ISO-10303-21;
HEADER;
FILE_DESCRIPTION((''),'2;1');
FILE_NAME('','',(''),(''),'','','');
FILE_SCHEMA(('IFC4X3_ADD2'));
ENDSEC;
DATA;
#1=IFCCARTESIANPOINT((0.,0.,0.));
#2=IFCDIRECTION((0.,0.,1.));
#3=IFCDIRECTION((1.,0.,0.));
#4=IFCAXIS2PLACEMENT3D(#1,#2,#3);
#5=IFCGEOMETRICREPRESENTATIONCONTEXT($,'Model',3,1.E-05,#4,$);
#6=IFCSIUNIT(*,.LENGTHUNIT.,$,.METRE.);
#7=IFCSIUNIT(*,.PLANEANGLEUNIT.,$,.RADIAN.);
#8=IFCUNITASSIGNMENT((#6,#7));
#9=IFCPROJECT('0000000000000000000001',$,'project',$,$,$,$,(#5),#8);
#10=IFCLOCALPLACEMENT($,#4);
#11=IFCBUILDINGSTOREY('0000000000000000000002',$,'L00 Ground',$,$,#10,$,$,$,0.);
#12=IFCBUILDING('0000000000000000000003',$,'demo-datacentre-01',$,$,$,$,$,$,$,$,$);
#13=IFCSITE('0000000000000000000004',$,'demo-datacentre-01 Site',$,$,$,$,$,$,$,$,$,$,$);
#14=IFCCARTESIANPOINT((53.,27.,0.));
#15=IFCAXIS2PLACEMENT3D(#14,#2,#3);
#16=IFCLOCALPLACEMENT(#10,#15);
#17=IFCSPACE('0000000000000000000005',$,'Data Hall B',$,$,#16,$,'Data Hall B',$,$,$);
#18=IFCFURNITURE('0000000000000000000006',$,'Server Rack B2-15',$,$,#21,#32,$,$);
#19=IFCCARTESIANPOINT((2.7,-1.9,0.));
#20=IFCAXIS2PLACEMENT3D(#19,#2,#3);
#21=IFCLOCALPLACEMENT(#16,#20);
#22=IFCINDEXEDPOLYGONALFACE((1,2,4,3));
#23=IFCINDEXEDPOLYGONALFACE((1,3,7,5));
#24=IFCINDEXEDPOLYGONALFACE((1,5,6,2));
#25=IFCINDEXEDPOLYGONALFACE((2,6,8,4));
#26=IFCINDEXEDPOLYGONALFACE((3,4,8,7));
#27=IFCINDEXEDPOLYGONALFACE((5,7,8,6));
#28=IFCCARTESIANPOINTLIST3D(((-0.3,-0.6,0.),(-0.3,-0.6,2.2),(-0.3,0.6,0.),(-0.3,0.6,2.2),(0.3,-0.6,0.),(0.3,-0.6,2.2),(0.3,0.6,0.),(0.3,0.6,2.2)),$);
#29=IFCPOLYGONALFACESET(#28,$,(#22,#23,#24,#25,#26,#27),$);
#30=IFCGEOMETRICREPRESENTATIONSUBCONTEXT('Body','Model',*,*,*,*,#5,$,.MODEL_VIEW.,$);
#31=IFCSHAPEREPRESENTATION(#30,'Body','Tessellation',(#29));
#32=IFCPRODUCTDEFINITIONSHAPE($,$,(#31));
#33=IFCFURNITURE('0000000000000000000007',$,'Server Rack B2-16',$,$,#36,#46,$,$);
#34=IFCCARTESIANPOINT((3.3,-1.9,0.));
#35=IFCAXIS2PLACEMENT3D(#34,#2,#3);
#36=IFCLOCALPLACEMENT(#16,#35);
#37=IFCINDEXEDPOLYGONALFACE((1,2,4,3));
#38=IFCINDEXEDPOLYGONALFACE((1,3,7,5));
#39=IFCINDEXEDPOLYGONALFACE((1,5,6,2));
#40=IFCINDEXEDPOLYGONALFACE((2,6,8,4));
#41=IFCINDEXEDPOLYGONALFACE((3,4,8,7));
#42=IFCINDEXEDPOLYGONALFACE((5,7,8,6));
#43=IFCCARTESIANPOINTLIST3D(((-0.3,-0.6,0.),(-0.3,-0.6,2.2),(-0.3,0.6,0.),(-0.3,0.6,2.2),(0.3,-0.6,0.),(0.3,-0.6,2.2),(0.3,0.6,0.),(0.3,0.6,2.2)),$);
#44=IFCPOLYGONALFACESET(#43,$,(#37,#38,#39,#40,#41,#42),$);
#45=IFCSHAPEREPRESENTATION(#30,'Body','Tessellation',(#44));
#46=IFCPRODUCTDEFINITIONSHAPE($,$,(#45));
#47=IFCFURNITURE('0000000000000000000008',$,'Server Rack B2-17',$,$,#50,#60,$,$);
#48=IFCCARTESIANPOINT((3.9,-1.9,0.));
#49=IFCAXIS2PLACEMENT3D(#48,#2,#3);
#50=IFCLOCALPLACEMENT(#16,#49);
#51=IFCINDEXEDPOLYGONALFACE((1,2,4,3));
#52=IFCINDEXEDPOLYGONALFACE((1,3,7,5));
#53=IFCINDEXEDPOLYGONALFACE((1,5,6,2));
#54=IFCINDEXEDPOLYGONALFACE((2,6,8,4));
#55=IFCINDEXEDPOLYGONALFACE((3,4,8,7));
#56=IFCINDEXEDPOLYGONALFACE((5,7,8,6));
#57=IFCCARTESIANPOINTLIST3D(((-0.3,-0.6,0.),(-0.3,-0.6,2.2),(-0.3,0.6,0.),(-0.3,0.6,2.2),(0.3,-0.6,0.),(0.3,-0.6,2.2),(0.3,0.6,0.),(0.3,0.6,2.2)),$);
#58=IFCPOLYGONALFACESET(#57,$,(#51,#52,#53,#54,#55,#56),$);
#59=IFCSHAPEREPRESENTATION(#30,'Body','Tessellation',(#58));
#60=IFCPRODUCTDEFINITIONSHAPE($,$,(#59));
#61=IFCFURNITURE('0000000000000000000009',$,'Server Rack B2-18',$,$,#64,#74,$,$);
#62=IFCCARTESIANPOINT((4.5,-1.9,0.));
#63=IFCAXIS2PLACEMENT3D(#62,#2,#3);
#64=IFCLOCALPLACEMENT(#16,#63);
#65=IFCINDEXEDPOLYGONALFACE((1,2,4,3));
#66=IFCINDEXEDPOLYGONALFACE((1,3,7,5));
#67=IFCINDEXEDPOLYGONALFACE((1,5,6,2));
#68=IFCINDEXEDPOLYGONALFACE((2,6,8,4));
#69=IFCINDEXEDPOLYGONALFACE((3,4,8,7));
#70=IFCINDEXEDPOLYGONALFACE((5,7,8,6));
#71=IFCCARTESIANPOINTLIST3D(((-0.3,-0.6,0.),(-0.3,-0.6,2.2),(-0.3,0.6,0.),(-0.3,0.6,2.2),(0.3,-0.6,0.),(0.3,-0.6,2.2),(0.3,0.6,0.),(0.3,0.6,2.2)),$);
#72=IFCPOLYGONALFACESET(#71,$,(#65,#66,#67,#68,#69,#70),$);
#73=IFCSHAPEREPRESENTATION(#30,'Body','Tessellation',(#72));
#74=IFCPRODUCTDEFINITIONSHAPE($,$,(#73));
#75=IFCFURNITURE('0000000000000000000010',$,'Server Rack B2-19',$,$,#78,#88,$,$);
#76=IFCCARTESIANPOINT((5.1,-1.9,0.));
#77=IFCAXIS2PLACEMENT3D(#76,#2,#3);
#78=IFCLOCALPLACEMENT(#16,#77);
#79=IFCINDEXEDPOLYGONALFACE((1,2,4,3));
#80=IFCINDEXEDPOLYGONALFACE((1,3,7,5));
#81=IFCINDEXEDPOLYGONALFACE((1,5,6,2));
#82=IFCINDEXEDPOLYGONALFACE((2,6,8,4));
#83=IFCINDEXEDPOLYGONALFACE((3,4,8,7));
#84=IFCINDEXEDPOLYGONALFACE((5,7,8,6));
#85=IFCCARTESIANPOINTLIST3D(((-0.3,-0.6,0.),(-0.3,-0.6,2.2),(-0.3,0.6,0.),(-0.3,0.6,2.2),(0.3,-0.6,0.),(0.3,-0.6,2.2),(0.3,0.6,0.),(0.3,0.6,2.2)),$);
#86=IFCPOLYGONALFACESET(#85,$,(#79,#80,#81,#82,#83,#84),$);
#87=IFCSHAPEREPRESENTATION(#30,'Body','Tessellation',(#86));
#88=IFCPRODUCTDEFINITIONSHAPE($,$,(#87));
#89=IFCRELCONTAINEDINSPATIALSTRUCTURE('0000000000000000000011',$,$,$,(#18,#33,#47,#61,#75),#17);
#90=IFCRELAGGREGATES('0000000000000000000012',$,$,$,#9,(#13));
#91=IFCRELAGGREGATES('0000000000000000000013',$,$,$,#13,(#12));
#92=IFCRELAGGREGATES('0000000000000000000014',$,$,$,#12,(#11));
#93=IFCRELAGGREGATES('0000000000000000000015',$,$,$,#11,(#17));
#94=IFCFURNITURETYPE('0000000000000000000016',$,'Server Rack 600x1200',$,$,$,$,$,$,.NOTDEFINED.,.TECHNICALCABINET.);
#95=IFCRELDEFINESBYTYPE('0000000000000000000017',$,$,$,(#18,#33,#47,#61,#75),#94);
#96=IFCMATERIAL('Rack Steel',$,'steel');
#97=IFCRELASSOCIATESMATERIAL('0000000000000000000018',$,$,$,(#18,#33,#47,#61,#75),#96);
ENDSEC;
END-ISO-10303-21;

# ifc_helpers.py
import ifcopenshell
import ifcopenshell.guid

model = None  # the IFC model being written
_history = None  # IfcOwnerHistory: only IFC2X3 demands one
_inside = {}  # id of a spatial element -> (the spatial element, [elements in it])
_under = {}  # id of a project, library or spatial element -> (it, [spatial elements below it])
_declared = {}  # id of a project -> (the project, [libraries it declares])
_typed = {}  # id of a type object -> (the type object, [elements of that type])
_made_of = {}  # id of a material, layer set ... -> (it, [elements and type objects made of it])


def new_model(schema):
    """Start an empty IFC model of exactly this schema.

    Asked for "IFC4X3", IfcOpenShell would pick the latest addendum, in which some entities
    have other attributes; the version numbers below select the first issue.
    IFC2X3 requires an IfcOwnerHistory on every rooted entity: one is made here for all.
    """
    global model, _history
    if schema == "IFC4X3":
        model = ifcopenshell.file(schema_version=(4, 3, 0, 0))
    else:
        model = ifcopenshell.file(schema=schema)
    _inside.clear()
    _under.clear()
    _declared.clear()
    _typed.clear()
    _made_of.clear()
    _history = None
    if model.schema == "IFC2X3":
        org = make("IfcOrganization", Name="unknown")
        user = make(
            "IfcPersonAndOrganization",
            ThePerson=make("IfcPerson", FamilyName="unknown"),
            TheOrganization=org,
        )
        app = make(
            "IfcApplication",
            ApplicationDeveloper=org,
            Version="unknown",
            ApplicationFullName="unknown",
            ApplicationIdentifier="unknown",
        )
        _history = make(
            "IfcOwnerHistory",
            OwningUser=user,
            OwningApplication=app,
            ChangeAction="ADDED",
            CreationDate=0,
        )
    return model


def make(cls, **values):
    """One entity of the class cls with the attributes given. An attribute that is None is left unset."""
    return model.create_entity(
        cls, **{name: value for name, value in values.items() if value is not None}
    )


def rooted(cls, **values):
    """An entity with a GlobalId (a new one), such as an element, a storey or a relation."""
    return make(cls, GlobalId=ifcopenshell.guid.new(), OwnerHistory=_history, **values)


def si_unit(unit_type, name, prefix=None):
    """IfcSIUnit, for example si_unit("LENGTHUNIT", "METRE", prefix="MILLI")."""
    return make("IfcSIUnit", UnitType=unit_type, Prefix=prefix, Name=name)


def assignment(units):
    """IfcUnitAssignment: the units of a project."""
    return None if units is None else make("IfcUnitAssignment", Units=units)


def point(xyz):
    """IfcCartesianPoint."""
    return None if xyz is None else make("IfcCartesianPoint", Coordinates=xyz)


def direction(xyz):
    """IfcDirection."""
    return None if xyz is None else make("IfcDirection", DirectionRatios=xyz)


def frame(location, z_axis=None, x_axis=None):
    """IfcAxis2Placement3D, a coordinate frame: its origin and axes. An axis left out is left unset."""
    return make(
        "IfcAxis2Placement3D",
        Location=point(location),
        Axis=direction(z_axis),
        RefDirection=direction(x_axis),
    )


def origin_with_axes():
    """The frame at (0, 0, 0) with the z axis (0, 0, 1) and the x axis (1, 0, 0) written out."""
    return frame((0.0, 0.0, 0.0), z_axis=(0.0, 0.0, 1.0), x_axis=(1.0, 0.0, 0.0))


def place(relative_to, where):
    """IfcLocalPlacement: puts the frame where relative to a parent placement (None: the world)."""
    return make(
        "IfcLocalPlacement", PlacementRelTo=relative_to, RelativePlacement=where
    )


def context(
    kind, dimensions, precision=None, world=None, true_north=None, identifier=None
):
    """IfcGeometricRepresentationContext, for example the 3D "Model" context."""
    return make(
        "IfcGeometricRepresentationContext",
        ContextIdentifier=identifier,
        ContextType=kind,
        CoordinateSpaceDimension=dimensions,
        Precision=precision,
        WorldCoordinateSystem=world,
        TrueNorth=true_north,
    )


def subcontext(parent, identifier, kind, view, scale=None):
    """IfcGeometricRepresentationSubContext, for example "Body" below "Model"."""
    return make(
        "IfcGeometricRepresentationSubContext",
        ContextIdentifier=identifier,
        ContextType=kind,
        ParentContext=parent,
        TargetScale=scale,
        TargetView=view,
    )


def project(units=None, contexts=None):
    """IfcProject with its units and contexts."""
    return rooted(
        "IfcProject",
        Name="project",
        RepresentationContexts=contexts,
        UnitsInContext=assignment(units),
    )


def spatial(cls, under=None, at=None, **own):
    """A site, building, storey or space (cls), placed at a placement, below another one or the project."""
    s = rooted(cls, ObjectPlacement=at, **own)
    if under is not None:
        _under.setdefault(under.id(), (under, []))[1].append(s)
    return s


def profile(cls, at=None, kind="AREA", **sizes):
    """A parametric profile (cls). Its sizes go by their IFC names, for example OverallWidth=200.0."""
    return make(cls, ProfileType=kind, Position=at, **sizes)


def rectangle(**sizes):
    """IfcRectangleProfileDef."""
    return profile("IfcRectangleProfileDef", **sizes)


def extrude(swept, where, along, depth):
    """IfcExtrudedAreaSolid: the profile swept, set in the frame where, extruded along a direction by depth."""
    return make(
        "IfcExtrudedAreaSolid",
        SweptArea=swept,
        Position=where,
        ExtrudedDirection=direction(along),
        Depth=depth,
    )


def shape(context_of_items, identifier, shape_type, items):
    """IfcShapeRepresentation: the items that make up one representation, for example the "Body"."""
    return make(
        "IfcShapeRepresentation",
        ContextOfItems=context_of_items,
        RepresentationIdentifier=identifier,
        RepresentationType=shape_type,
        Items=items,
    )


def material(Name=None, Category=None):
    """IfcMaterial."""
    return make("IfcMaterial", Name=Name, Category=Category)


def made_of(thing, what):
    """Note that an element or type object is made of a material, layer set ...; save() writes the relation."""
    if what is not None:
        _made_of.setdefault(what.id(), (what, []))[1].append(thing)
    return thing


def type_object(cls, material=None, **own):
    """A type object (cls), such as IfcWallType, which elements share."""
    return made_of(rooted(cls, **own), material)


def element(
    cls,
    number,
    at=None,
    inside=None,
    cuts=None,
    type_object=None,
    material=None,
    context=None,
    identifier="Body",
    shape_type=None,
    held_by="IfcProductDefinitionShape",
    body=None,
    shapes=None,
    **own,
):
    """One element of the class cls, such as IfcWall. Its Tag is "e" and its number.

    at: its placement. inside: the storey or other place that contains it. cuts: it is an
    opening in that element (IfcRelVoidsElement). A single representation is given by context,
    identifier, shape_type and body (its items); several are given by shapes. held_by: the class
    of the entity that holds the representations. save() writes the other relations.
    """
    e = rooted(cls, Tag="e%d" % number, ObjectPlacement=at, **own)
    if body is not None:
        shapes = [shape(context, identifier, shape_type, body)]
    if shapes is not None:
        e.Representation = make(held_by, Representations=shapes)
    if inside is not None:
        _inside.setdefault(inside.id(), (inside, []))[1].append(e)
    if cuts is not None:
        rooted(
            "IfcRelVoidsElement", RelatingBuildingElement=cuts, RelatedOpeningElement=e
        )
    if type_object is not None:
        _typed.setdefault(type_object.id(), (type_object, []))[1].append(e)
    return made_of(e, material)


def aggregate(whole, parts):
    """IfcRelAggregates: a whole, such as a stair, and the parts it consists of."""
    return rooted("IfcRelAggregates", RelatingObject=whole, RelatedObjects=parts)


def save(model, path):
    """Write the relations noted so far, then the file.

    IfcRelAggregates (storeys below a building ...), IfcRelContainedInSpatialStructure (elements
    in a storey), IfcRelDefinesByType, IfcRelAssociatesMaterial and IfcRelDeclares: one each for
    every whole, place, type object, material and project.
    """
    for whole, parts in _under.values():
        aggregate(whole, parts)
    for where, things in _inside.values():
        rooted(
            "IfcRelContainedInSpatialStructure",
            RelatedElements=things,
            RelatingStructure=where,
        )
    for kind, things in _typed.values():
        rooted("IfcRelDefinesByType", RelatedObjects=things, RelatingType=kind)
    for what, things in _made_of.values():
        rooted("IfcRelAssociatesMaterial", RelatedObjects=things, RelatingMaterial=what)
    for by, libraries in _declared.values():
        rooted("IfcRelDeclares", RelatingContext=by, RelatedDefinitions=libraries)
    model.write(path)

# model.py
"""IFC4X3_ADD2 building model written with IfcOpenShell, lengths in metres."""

from ifc_helpers import new_model, si_unit, frame, origin_with_axes, place, context, subcontext, project, spatial, rectangle, extrude, material, type_object, element, save


model = new_model("IFC4X3_ADD2")

# Units and contexts
model_context = context("Model", 3, precision=1e-05, world=origin_with_axes())
body_context = subcontext(model_context, "Body", "Model", "MODEL_VIEW")
ifc_project = project(units=[si_unit("LENGTHUNIT", "METRE"), si_unit("PLANEANGLEUNIT", "RADIAN")], contexts=[model_context])

# Site, building, storey
site = spatial("IfcSite", under=ifc_project, Name="demo-datacentre-01 Site")
building = spatial("IfcBuilding", under=site, Name="demo-datacentre-01")
storey_placement = place(None, origin_with_axes())
storey = spatial("IfcBuildingStorey", under=building, at=storey_placement, Name="L00 Ground", Elevation=0.0)

# Shared definitions
space_placement = place(storey_placement, frame((53.0, 27.0, 0.0), z_axis=(0.0, 0.0, 1.0), x_axis=(1.0, 0.0, 0.0)))
space = spatial("IfcSpace", under=storey, at=space_placement, Name="Data Hall B", LongName="Data Hall B")

# Furniture
ifc_material_1 = material(Name="Rack Steel", Category="steel")
furniture_type = type_object("IfcFurnitureType", Name="Server Rack 600x1200", AssemblyPlace="NOTDEFINED", PredefinedType="TECHNICALCABINET")
for number, where, z_axis, x_axis, name in (
    (1, (2.7, -1.9, 0.0), (0.0, 0.0, 1.0), (1.0, 0.0, 0.0), "Server Rack B2-15"),
    (2, (3.3, -1.9, 0.0), (0.0, 0.0, 1.0), (1.0, 0.0, 0.0), "Server Rack B2-16"),
    (3, (3.9, -1.9, 0.0), (0.0, 0.0, 1.0), (1.0, 0.0, 0.0), "Server Rack B2-17"),
    (4, (4.5, -1.9, 0.0), (0.0, 0.0, 1.0), (1.0, 0.0, 0.0), "Server Rack B2-18"),
    (5, (5.1, -1.9, 0.0), (0.0, 0.0, 1.0), (1.0, 0.0, 0.0), "Server Rack B2-19"),
):
    element("IfcFurniture", number, at=place(space_placement, frame(where, z_axis=z_axis, x_axis=x_axis)), inside=space, type_object=furniture_type, material=ifc_material_1, Name=name, context=body_context, shape_type="SweptSolid", body=[
        extrude(rectangle(XDim=0.6, YDim=1.2), origin_with_axes(), (0.0, 0.0, 1.0), 2.2),
    ])

save(model, "model.ifc")
